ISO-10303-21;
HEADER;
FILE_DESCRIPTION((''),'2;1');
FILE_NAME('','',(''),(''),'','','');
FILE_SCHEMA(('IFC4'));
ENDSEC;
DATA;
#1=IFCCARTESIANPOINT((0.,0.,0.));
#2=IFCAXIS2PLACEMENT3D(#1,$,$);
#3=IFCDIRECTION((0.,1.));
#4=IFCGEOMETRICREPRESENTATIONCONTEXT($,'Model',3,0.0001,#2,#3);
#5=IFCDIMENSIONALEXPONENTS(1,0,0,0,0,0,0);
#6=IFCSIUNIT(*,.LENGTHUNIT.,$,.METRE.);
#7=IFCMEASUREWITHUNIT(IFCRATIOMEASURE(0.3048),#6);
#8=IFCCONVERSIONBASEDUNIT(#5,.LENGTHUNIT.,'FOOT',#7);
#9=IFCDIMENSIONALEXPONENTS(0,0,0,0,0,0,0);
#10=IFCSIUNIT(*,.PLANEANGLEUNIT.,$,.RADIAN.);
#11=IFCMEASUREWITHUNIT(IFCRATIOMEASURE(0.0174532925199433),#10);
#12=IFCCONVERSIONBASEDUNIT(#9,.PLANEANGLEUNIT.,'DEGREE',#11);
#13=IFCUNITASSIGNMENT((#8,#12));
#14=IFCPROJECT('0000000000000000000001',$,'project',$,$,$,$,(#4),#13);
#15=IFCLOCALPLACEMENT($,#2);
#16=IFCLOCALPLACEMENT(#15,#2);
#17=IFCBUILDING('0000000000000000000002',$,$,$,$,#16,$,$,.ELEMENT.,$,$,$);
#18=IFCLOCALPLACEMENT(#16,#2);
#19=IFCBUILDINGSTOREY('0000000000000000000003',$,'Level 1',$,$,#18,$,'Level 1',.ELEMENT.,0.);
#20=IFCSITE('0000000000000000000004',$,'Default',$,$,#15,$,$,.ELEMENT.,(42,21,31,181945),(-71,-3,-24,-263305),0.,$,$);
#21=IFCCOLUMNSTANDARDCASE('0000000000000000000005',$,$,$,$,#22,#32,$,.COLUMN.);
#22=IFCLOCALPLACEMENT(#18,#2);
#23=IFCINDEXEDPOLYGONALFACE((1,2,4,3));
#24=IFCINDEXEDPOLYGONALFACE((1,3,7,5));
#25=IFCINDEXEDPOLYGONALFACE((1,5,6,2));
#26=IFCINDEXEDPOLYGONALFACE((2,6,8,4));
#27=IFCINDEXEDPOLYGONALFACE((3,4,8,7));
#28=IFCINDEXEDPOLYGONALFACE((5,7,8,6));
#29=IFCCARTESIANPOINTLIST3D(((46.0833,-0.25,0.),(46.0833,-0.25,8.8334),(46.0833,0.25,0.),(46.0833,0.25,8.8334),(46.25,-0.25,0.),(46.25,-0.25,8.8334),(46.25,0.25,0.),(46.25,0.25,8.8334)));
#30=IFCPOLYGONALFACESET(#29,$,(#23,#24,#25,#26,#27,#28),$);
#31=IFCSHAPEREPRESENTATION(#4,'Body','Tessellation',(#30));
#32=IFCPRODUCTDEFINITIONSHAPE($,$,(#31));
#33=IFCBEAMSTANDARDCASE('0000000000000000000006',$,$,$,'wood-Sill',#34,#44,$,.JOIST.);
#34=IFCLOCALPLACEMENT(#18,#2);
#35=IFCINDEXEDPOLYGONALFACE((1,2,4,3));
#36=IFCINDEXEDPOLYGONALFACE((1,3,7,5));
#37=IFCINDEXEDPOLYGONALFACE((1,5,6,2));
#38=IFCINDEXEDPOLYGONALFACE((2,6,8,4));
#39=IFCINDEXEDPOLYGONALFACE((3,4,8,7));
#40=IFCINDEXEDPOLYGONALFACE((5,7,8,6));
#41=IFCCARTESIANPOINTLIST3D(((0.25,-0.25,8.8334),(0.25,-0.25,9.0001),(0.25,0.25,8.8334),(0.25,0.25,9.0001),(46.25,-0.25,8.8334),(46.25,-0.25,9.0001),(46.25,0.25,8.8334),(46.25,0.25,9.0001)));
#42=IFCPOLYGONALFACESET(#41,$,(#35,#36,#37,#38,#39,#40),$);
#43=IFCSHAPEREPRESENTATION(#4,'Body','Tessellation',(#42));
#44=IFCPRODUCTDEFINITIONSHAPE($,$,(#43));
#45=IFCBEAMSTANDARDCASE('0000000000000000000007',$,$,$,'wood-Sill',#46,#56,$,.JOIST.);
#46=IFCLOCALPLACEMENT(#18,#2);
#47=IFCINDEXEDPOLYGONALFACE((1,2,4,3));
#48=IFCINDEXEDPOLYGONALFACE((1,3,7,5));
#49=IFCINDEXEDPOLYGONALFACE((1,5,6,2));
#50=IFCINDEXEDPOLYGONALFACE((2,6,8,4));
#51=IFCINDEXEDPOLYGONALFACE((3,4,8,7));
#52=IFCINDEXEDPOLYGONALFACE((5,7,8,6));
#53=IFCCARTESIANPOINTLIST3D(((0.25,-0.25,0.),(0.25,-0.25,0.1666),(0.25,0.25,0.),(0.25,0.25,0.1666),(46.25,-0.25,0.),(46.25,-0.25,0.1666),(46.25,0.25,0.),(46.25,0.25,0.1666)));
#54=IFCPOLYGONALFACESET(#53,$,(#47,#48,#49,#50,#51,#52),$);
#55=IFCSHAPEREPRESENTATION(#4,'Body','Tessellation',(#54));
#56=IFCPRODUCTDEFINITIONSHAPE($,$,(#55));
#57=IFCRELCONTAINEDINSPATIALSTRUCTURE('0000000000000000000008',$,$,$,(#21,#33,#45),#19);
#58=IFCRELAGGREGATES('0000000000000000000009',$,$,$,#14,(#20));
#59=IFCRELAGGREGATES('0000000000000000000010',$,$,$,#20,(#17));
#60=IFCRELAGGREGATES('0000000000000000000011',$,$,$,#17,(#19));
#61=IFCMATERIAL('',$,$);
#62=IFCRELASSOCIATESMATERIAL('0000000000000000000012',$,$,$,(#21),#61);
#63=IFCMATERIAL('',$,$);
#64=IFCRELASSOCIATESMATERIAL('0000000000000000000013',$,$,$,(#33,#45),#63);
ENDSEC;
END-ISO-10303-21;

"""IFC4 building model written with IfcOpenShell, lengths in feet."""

from ifc_helpers import new_model, entity, si_unit, converted_unit, direction, frame, origin, origin_with_axes, place, context, project, spatial, rectangle, extrude, material, element, save


model = new_model("IFC4")

# Units and contexts
model_context = context("Model", 3, precision=0.0001, world=origin(), true_north=direction((0.0, 1.0)))
ifc_project = project(units=[converted_unit("LENGTHUNIT", "FOOT", entity("IfcRatioMeasure", 0.3048), si_unit("LENGTHUNIT", "METRE"), dimensions=[1, 0, 0, 0, 0, 0, 0]), converted_unit("PLANEANGLEUNIT", "DEGREE", entity("IfcRatioMeasure", 0.0174532925199433), si_unit("PLANEANGLEUNIT", "RADIAN"), dimensions=[0, 0, 0, 0, 0, 0, 0])], contexts=[model_context])

# Site, building, storey
site_placement = place(None, origin())
site = spatial("IfcSite", under=ifc_project, at=site_placement, Name="Default", CompositionType="ELEMENT", RefLatitude=(42, 21, 31, 181945), RefLongitude=(-71, -3, -24, -263305), RefElevation=0.0)
building_placement = place(site_placement, origin())
building = spatial("IfcBuilding", under=site, at=building_placement, CompositionType="ELEMENT")
storey_placement = place(building_placement, origin())
storey = spatial("IfcBuildingStorey", under=building, at=storey_placement, Name="Level 1", LongName="Level 1", CompositionType="ELEMENT", Elevation=0.0)

# Column
ifc_material_1 = material(Name="")
placement = place(storey_placement, frame((46.25, 0.0, 0.0), z_axis=(0.0, 0.0, 1.0), x_axis=(-1.0, 0.0, 0.0)))
for number, where, z_axis, x_axis in (
    (1, (0.0833, 0.0, 0.0), (0.0, 0.0, 1.0), (1.0, 0.0, 0.0)),
):
    element("IfcColumnStandardCase", number, at=place(placement, frame(where, z_axis=z_axis, x_axis=x_axis)), inside=storey, material=ifc_material_1, PredefinedType="COLUMN", context=model_context, shape_type="SweptSolid", body=[
        extrude(rectangle(XDim=0.1667, YDim=0.5), origin(), (0.0, 0.0, 1.0), 8.8334),
    ])

# Beams
ifc_material_2 = material(Name="")
for number, where, z_axis, x_axis in (
    (2, (0.0, 0.0, 8.9167), (1.0, 0.0, 0.0), (0.0, 0.0, 1.0)),
    (3, (0.0, 0.0, 0.0833), (1.0, 0.0, 0.0), (0.0, 0.0, 1.0)),
):
    element("IfcBeamStandardCase", number, at=place(placement, frame(where, z_axis=z_axis, x_axis=x_axis)), inside=storey, material=ifc_material_2, ObjectType="wood-Sill", PredefinedType="JOIST", context=model_context, shape_type="SweptSolid", body=[
        extrude(rectangle(XDim=0.1667, YDim=0.5), origin_with_axes(), (0.0, 0.0, 1.0), 46.0),
    ])

save(model, "model.ifc")
